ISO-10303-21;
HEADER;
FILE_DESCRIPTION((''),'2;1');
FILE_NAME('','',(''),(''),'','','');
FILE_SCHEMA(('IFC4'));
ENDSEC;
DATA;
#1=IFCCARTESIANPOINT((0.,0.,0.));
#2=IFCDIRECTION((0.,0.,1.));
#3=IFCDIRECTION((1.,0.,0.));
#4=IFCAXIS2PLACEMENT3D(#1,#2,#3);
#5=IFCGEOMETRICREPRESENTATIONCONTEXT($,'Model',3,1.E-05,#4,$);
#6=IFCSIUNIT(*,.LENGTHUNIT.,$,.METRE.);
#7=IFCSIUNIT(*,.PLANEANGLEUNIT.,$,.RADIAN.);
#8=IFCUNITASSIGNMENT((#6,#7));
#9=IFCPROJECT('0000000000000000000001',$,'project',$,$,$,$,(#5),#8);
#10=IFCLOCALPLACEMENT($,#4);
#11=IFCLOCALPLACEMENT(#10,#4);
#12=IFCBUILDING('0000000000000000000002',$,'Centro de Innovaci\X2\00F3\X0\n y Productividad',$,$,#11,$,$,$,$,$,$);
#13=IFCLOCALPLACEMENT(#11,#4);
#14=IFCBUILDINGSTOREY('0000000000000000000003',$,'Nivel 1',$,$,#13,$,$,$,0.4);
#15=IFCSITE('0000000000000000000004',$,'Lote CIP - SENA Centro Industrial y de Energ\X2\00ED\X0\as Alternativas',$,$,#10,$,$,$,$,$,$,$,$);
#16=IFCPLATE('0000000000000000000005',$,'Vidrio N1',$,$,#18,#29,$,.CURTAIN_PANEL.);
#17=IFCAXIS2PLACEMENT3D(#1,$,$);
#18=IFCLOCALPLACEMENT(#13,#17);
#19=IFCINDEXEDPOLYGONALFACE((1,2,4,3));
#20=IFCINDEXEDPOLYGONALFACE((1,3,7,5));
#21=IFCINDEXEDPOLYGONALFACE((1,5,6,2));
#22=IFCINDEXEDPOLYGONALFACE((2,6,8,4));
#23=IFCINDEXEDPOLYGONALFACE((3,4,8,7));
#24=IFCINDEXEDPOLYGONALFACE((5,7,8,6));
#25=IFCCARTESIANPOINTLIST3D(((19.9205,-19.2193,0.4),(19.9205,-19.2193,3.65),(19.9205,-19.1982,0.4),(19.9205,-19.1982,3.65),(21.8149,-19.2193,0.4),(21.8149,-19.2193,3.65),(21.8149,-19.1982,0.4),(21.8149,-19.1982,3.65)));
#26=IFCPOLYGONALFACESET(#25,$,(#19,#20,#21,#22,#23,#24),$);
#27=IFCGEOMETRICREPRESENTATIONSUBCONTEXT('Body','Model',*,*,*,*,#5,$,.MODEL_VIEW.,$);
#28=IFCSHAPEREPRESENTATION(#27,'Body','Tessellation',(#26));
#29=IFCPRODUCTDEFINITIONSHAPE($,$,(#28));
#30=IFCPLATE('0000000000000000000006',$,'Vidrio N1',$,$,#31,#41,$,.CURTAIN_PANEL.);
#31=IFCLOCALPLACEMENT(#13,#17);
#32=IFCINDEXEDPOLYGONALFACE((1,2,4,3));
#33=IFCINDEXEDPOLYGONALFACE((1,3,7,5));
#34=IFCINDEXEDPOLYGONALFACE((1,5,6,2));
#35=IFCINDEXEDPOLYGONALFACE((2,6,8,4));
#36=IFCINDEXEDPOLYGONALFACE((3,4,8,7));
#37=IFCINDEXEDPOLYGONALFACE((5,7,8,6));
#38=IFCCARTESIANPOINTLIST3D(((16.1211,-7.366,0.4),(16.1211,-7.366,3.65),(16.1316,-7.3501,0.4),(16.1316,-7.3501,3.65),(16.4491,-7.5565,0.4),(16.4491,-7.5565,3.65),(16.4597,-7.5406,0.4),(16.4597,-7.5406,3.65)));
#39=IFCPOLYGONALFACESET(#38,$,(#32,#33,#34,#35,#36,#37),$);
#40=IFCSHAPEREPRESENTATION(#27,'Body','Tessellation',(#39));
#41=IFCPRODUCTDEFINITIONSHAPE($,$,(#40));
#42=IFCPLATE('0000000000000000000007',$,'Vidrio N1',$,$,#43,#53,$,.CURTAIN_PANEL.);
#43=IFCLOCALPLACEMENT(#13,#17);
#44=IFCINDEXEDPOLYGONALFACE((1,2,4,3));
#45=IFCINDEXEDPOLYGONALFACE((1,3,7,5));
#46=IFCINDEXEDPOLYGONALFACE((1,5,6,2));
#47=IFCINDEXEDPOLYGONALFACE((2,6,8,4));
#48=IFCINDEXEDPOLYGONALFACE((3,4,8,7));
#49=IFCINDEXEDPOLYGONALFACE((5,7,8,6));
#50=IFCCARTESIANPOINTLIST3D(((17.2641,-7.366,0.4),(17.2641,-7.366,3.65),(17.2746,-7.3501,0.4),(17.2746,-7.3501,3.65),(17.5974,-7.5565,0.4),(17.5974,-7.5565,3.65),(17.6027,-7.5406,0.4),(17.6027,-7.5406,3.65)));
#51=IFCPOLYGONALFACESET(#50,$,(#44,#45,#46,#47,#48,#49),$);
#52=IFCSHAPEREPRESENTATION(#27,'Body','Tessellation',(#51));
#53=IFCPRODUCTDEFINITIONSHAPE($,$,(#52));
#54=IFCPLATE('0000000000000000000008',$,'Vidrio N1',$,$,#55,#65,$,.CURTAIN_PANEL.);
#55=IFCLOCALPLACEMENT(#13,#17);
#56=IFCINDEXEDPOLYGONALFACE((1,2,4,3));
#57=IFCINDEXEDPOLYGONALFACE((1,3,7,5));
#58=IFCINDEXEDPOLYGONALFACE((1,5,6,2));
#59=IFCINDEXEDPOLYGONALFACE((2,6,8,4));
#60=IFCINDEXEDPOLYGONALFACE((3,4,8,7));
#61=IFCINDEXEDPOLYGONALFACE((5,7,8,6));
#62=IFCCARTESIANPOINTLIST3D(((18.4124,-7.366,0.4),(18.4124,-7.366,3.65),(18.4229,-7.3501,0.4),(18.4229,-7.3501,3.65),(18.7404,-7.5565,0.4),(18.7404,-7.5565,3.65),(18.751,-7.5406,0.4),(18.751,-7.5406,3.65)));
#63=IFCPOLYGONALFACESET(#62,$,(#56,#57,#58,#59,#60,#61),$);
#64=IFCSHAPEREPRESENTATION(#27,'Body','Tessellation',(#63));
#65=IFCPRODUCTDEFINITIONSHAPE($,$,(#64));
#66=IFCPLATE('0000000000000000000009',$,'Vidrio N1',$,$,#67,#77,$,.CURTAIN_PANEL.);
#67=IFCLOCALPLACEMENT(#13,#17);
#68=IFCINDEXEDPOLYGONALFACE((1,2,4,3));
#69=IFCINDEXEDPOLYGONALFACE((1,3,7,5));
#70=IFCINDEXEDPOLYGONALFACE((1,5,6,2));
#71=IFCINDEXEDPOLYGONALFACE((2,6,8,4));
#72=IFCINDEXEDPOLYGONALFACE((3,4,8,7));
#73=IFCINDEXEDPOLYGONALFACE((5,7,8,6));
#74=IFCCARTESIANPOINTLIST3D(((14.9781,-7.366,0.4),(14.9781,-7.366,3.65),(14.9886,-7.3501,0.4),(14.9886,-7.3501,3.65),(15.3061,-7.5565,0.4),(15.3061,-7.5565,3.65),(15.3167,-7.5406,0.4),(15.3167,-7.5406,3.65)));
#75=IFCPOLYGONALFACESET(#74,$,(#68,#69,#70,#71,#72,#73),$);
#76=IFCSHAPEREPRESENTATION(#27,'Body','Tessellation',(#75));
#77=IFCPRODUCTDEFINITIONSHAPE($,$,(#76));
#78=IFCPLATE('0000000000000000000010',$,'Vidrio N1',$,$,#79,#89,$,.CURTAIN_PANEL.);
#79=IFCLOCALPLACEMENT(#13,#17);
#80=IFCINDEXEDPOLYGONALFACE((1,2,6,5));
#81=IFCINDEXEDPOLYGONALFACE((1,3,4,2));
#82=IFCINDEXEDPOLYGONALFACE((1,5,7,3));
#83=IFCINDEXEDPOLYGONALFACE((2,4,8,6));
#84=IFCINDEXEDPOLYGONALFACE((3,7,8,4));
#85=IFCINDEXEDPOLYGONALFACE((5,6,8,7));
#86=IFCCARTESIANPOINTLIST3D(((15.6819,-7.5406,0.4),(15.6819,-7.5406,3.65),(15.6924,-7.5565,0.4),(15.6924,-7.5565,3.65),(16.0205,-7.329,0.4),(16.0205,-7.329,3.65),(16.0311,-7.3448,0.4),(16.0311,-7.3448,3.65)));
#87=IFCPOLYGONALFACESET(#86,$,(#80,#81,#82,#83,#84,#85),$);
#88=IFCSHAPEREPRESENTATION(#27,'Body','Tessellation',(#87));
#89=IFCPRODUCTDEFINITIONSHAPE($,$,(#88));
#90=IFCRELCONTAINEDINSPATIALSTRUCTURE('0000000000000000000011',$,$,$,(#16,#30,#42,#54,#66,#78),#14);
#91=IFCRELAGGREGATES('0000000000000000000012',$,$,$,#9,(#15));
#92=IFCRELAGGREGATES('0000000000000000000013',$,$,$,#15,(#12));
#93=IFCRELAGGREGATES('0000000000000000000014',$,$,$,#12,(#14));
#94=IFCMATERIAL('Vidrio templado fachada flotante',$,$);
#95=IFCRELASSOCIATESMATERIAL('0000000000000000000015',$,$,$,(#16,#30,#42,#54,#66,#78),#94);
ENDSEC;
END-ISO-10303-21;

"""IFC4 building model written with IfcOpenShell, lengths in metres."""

from ifc_helpers import new_model, si_unit, frame, origin_with_axes, place, context, subcontext, project, spatial, polyline, outline, extrude, material, element, save


model = new_model("IFC4")

# Units and contexts
model_context = context("Model", 3, precision=1e-05, world=origin_with_axes())
body_context = subcontext(model_context, "Body", "Model", "MODEL_VIEW")
ifc_project = project(units=[si_unit("LENGTHUNIT", "METRE"), si_unit("PLANEANGLEUNIT", "RADIAN")], contexts=[model_context])

# Site, building, storey
site_placement = place(None, origin_with_axes())
site = spatial("IfcSite", under=ifc_project, at=site_placement, Name="Lote CIP - SENA Centro Industrial y de Energías Alternativas")
building_placement = place(site_placement, origin_with_axes())
building = spatial("IfcBuilding", under=site, at=building_placement, Name="Centro de Innovación y Productividad")
storey_placement = place(building_placement, origin_with_axes())
storey = spatial("IfcBuildingStorey", under=building, at=storey_placement, Name="Nivel 1", Elevation=0.4)

# Plates
ifc_material = material(Name="Vidrio templado fachada flotante")
plate_1_placement = place(storey_placement, origin_with_axes())
element("IfcPlate", 1, at=plate_1_placement, inside=storey, material=ifc_material, Name="Vidrio N1", PredefinedType="CURTAIN_PANEL", context=body_context, shape_type="SweptSolid", body=[
    extrude(outline(polyline([(21.8149, -19.1982), (21.8149, -19.2193), (19.9205, -19.2193), (19.9205, -19.1982), (21.8149, -19.1982)])), frame((0.0, 0.0, 0.4)), (0.0, 0.0, 1.0), 3.25),
])
plate_2_placement = place(storey_placement, origin_with_axes())
element("IfcPlate", 2, at=plate_2_placement, inside=storey, material=ifc_material, Name="Vidrio N1", PredefinedType="CURTAIN_PANEL", context=body_context, shape_type="SweptSolid", body=[
    extrude(outline(polyline([(16.1211, -7.366), (16.1316, -7.3501), (16.4597, -7.5406), (16.4491, -7.5565), (16.1211, -7.366)])), frame((0.0, 0.0, 0.4)), (0.0, 0.0, 1.0), 3.25),
])
plate_3_placement = place(storey_placement, origin_with_axes())
element("IfcPlate", 3, at=plate_3_placement, inside=storey, material=ifc_material, Name="Vidrio N1", PredefinedType="CURTAIN_PANEL", context=body_context, shape_type="SweptSolid", body=[
    extrude(outline(polyline([(17.2641, -7.366), (17.2746, -7.3501), (17.6027, -7.5406), (17.5974, -7.5565), (17.2641, -7.366)])), frame((0.0, 0.0, 0.4)), (0.0, 0.0, 1.0), 3.25),
])
plate_4_placement = place(storey_placement, origin_with_axes())
element("IfcPlate", 4, at=plate_4_placement, inside=storey, material=ifc_material, Name="Vidrio N1", PredefinedType="CURTAIN_PANEL", context=body_context, shape_type="SweptSolid", body=[
    extrude(outline(polyline([(18.4229, -7.3501), (18.751, -7.5406), (18.7404, -7.5565), (18.4124, -7.366), (18.4229, -7.3501)])), frame((0.0, 0.0, 0.4)), (0.0, 0.0, 1.0), 3.25),
])
plate_5_placement = place(storey_placement, origin_with_axes())
element("IfcPlate", 5, at=plate_5_placement, inside=storey, material=ifc_material, Name="Vidrio N1", PredefinedType="CURTAIN_PANEL", context=body_context, shape_type="SweptSolid", body=[
    extrude(outline(polyline([(15.3061, -7.5565), (14.9781, -7.366), (14.9886, -7.3501), (15.3167, -7.5406), (15.3061, -7.5565)])), frame((0.0, 0.0, 0.4)), (0.0, 0.0, 1.0), 3.25),
])
plate_6_placement = place(storey_placement, origin_with_axes())
element("IfcPlate", 6, at=plate_6_placement, inside=storey, material=ifc_material, Name="Vidrio N1", PredefinedType="CURTAIN_PANEL", context=body_context, shape_type="SweptSolid", body=[
    extrude(outline(polyline([(16.0205, -7.329), (16.0311, -7.3448), (15.6924, -7.5565), (15.6819, -7.5406), (16.0205, -7.329)])), frame((0.0, 0.0, 0.4)), (0.0, 0.0, 1.0), 3.25),
])

save(model, "model.ifc")
